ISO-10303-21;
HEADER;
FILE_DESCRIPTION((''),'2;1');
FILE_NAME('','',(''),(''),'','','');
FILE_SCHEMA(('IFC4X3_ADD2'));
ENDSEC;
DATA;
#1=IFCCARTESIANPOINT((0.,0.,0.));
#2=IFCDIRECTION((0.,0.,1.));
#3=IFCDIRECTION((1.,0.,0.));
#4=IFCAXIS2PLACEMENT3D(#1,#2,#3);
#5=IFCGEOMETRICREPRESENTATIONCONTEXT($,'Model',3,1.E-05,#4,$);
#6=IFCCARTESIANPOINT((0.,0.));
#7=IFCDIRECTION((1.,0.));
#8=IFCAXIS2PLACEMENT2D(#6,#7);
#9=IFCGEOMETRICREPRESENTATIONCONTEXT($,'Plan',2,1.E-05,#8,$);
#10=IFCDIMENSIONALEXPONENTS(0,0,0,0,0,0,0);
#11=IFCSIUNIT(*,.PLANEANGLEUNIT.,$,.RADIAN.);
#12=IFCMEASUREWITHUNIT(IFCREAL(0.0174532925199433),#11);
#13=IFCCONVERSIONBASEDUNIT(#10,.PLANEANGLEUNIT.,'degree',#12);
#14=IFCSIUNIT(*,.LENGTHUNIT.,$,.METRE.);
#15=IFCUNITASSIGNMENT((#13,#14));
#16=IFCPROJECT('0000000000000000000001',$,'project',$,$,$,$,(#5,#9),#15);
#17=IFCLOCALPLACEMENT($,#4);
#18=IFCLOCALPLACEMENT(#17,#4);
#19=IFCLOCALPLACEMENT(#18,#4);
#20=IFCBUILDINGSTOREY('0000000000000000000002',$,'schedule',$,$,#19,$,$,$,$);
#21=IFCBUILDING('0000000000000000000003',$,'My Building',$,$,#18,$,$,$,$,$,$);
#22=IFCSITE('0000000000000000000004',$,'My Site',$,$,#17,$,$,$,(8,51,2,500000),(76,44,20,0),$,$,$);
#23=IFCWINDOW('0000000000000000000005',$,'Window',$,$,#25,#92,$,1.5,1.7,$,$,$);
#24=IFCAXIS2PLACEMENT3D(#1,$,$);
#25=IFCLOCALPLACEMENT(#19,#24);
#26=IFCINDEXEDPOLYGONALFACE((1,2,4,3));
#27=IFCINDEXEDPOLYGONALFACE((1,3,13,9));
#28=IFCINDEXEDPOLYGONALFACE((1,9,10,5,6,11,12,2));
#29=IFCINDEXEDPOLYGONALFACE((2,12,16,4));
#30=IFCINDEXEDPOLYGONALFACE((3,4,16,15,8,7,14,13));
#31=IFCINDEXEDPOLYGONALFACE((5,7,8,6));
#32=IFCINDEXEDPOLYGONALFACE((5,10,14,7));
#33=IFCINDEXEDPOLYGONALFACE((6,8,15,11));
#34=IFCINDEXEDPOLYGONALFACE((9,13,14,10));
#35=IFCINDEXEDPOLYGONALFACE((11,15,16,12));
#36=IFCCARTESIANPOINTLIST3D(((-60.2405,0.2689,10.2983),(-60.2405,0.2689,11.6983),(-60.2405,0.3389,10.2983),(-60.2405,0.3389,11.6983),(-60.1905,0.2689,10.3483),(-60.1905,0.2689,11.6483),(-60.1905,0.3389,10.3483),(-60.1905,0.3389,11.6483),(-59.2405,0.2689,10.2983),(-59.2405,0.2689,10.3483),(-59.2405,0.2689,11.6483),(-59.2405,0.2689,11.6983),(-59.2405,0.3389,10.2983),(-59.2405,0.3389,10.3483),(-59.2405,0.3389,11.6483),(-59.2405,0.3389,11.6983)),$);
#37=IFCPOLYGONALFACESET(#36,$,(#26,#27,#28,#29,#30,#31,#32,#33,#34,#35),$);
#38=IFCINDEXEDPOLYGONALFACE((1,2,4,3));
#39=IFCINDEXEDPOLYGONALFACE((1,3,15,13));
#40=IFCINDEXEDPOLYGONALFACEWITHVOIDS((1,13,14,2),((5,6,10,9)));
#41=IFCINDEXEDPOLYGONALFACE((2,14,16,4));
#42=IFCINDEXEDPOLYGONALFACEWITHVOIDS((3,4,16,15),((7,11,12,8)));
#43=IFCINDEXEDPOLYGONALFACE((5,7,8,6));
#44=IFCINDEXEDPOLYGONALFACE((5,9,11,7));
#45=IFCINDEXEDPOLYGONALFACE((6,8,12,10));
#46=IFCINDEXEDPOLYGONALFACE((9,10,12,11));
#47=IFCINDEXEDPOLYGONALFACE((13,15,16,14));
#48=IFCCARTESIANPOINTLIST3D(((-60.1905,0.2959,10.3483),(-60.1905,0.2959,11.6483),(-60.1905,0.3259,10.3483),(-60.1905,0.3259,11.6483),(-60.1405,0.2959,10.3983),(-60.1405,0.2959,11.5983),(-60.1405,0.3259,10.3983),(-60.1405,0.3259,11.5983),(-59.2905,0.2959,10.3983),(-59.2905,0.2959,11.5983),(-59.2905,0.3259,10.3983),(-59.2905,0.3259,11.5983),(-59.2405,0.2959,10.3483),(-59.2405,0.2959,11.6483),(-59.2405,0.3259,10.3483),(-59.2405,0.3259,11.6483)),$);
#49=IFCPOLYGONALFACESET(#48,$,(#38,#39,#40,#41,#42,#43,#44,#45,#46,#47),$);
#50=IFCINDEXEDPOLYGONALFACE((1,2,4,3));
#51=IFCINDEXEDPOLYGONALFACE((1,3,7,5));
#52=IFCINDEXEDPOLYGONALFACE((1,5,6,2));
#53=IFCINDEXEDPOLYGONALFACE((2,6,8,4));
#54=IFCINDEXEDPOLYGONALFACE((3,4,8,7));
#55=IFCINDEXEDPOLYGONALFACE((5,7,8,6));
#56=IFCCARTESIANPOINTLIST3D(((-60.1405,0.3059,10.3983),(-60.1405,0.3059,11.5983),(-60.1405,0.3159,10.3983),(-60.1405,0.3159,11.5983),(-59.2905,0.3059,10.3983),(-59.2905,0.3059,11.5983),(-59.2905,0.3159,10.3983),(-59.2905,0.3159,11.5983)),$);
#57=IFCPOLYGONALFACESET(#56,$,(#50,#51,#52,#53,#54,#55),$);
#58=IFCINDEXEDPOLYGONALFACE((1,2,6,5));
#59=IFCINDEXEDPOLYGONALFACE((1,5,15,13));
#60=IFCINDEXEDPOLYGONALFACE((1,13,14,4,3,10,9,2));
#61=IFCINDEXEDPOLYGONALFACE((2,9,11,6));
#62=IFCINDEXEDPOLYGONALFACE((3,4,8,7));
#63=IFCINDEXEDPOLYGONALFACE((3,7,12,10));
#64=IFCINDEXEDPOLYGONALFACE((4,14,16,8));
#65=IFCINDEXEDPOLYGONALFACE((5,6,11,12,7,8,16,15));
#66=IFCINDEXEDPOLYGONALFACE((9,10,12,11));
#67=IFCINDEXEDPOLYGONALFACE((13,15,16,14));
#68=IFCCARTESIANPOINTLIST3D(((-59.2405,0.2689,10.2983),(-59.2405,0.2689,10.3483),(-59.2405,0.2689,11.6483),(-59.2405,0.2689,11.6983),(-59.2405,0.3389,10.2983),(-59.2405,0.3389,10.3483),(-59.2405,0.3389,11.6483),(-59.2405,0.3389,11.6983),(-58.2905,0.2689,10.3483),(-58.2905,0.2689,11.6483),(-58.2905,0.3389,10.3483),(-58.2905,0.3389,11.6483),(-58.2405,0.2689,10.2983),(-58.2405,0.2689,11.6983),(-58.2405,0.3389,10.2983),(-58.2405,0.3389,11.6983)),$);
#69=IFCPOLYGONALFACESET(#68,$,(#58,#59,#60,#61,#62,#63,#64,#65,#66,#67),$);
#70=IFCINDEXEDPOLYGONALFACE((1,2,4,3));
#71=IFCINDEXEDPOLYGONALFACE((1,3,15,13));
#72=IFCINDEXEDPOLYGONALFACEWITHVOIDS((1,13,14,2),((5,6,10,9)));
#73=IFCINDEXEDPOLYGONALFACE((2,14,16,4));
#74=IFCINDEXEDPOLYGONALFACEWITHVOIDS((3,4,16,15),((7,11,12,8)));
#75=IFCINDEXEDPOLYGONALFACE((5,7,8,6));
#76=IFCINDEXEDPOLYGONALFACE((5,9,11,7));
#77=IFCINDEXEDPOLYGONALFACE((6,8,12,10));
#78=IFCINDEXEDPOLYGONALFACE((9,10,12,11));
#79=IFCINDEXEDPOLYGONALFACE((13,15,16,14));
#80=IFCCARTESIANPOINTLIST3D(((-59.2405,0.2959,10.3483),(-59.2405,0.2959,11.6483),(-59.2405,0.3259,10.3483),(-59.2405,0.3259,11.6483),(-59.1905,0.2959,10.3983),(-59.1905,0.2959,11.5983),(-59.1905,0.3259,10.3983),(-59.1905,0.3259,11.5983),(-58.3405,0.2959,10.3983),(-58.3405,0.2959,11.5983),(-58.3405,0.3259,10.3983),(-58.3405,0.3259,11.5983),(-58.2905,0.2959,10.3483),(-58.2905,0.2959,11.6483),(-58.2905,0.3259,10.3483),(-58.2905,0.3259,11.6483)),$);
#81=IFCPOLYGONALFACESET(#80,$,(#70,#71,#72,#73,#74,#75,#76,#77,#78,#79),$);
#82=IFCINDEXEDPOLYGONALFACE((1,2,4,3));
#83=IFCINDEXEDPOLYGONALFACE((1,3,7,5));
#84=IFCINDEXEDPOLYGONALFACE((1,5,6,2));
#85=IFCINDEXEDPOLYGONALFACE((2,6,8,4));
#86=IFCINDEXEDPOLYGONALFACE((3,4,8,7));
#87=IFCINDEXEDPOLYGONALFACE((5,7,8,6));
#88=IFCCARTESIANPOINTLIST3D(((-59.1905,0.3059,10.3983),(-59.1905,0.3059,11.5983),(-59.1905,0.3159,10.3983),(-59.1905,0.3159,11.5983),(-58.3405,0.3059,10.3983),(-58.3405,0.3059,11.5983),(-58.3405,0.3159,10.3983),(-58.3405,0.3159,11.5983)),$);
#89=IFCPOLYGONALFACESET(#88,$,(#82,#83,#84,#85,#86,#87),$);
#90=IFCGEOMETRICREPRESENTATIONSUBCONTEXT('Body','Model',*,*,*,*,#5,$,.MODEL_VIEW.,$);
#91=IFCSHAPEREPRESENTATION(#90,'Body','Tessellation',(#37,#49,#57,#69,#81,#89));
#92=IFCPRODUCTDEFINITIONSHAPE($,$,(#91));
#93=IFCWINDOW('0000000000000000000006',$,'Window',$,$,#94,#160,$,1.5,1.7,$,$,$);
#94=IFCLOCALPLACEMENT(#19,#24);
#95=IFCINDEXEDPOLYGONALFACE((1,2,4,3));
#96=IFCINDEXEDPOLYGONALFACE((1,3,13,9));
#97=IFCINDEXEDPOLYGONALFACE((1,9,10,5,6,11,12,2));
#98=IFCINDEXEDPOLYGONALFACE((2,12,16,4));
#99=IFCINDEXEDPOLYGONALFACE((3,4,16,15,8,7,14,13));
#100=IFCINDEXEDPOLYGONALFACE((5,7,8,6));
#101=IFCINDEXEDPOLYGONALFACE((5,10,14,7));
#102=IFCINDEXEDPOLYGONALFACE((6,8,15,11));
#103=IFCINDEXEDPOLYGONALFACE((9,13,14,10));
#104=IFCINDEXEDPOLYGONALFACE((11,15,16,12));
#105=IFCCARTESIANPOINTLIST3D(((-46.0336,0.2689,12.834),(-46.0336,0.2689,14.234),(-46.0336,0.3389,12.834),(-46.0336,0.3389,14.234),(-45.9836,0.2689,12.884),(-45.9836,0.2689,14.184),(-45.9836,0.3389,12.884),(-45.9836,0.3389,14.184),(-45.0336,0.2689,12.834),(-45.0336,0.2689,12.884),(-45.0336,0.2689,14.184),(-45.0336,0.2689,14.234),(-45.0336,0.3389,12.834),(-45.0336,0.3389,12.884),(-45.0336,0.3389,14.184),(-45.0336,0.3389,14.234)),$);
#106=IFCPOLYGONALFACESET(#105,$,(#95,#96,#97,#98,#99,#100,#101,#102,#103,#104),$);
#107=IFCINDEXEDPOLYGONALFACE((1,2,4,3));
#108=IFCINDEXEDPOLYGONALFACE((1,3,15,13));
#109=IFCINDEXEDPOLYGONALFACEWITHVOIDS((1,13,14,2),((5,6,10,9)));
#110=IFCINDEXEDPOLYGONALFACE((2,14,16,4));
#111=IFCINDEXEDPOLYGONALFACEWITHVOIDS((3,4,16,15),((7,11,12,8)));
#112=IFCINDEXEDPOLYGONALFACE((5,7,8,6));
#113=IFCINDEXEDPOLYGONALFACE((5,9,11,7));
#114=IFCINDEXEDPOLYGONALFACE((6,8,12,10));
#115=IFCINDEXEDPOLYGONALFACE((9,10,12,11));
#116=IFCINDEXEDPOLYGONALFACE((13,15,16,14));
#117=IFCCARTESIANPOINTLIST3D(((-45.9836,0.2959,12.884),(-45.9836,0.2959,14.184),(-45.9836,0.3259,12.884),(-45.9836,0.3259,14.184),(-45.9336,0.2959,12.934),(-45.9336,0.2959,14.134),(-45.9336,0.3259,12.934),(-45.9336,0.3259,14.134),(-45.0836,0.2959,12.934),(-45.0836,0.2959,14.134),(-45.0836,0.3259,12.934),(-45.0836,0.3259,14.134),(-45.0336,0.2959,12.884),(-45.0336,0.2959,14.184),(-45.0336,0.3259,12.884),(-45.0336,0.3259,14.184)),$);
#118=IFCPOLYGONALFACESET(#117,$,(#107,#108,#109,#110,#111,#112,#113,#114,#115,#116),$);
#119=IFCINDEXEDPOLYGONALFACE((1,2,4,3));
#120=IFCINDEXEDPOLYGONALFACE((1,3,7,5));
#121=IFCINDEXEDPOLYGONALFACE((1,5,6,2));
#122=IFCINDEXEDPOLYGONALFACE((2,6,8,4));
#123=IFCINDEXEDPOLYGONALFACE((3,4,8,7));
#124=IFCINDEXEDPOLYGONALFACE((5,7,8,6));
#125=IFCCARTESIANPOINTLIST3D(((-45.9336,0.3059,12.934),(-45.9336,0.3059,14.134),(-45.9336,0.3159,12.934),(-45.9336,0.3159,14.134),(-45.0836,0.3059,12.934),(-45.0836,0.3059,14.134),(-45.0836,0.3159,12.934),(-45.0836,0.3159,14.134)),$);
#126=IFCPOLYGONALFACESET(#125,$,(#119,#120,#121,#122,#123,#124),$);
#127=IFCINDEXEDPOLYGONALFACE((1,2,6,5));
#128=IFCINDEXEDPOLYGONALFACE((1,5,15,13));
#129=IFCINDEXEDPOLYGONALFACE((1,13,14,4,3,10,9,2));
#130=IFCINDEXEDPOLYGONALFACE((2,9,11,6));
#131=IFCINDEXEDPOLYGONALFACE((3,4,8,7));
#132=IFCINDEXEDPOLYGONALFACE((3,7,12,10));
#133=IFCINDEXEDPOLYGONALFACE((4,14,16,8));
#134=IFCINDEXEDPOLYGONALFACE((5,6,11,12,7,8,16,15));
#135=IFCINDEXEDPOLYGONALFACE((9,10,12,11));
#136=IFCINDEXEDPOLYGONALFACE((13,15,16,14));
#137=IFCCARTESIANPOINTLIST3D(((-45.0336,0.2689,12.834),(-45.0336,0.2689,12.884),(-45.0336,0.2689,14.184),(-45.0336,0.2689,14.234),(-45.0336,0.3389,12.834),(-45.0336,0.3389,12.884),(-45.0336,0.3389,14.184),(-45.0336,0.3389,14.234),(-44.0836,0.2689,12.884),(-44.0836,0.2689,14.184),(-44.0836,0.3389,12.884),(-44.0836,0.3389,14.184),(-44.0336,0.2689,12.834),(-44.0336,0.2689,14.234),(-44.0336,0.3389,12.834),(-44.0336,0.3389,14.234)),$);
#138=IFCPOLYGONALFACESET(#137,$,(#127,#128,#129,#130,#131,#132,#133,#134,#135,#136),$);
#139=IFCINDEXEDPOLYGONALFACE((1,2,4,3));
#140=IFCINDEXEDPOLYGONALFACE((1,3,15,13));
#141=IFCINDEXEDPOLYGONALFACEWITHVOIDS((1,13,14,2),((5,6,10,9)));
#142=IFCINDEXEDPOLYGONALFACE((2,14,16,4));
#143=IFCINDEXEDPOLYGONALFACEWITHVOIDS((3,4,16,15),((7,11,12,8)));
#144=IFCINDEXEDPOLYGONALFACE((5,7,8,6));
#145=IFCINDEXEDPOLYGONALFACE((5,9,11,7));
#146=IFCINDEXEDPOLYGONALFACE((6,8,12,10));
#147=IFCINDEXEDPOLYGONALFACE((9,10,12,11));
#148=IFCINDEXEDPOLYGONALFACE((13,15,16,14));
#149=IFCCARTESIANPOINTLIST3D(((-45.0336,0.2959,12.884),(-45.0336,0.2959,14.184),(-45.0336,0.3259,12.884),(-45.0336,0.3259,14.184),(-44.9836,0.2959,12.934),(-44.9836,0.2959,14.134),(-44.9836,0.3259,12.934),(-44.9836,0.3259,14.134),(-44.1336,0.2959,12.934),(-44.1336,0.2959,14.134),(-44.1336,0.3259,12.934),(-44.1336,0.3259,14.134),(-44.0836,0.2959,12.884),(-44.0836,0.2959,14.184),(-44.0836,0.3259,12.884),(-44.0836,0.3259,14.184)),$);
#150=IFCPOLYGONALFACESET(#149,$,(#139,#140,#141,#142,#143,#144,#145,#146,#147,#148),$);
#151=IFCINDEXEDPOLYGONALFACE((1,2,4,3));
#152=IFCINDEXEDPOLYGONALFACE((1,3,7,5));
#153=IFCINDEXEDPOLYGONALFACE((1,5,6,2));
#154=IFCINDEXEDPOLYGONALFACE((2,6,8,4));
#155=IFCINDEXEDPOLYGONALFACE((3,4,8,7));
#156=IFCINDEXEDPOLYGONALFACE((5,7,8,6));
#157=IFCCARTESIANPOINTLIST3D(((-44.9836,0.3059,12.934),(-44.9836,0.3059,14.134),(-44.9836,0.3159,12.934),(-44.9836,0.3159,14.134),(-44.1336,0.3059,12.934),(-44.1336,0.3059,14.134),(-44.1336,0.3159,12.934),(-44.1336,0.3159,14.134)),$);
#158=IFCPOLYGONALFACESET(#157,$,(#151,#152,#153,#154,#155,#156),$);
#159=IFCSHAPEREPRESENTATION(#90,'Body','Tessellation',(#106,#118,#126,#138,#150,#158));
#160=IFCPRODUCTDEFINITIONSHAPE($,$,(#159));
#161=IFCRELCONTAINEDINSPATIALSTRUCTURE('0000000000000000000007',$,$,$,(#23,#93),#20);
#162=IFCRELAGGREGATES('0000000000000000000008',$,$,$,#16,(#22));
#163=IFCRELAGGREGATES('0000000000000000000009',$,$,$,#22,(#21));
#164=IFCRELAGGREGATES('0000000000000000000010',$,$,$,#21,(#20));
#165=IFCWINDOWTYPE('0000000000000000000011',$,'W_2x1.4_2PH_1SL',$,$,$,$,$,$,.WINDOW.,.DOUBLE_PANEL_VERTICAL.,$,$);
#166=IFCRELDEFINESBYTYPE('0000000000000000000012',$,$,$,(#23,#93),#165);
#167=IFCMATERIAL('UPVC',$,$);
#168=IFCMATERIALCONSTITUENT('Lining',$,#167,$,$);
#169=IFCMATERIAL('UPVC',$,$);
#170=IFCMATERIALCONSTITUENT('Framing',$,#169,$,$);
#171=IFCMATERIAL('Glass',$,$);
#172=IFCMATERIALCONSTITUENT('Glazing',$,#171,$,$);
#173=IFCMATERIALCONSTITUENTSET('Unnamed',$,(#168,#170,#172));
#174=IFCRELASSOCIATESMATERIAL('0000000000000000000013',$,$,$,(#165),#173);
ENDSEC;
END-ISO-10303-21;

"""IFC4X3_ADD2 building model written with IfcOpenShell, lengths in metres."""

from ifc_helpers import new_model, entity, si_unit, converted_unit, frame, origin_with_axes, origin_2d_with_axis, place, context, subcontext, project, spatial, line, indexed_curve, outline, extrude, shape, source, transform, mapped, material, constituent, constituent_set, type_object, type_shapes, element, save


model = new_model("IFC4X3_ADD2")

# Units and contexts
model_context = context("Model", 3, precision=1e-05, world=origin_with_axes())
plan_context = context("Plan", 2, precision=1e-05, world=origin_2d_with_axis())
body_context_1 = subcontext(model_context, "Body", "Model", "MODEL_VIEW")
body_context_2 = subcontext(plan_context, "Body", "Plan", "PLAN_VIEW")
ifc_project = project(units=[converted_unit("PLANEANGLEUNIT", "degree", entity("IfcReal", 0.0174532925199433), si_unit("PLANEANGLEUNIT", "RADIAN"), dimensions=[0, 0, 0, 0, 0, 0, 0]), si_unit("LENGTHUNIT", "METRE")], contexts=[model_context, plan_context])

# Site, building, storey
site_placement = place(None, origin_with_axes())
site = spatial("IfcSite", under=ifc_project, at=site_placement, Name="My Site", RefLatitude=(8, 51, 2, 500000), RefLongitude=(76, 44, 20, 0))
building_placement = place(site_placement, origin_with_axes())
building = spatial("IfcBuilding", under=site, at=building_placement, Name="My Building")
storey_placement = place(building_placement, origin_with_axes())
storey = spatial("IfcBuildingStorey", under=building, at=storey_placement, Name="schedule")

# Windows
ifc_material_1 = material(Name="UPVC")
ifc_constituent_1 = constituent(ifc_material_1, Name="Lining")
ifc_material_2 = material(Name="UPVC")
ifc_constituent_2 = constituent(ifc_material_2, Name="Framing")
ifc_material_3 = material(Name="Glass")
ifc_constituent_3 = constituent(ifc_material_3, Name="Glazing")
ifc_constituent_set_1 = constituent_set(constituents=[ifc_constituent_1, ifc_constituent_2, ifc_constituent_3], Name="Unnamed")
window_type_1 = type_object("IfcWindowType", Name="W_2x1.4_2PH_1SL", PartitioningType="DOUBLE_PANEL_VERTICAL", PredefinedType="WINDOW", material=ifc_constituent_set_1)
shared_shape_1 = source(origin_with_axes(), body_context_1, "Body", "SweptSolid", [
    extrude(outline(indexed_curve([(1.0, 0.0), (0.0, 0.0), (0.0, 1.4), (1.0, 1.4), (1.0, 1.35), (0.05, 1.35), (0.05, 0.05), (1.0, 0.05)], segments=[line(1, 2, 3, 4, 5, 6, 7, 8, 1)])), frame((0.0, 0.0, 0.0), z_axis=(0.0, -1.0, 0.0), x_axis=(1.0, 0.0, 0.0)), (0.0, 0.0, -1.0), 0.07),
    extrude(outline(indexed_curve([(0.0, 0.0), (0.95, 0.0), (0.95, 1.3), (0.0, 1.3)], segments=[line(1, 2, 3, 4, 1)]), holes=[indexed_curve([(0.05, 0.05), (0.9, 0.05), (0.9, 1.25), (0.05, 1.25)], segments=[line(1, 2, 3, 4, 1)])]), frame((0.05, 0.027, 0.05), z_axis=(0.0, -1.0, 0.0), x_axis=(1.0, 0.0, 0.0)), (0.0, 0.0, -1.0), 0.03),
    extrude(outline(indexed_curve([(0.05, 0.05), (0.9, 0.05), (0.9, 1.25), (0.05, 1.25)], segments=[line(1, 2, 3, 4, 1)])), frame((0.05, 0.037, 0.05), z_axis=(0.0, -1.0, 0.0), x_axis=(1.0, 0.0, 0.0)), (0.0, 0.0, -1.0), 0.01),
    extrude(outline(indexed_curve([(0.0, 1.4), (1.0, 1.4), (1.0, 0.0), (0.0, 0.0), (0.0, 0.05), (0.95, 0.05), (0.95, 1.35), (0.0, 1.35)], segments=[line(1, 2, 3, 4, 5, 6, 7, 8, 1)])), frame((1.0, 0.0, 0.0), z_axis=(0.0, -1.0, 0.0), x_axis=(1.0, 0.0, 0.0)), (0.0, 0.0, -1.0), 0.07),
    extrude(outline(indexed_curve([(0.0, 0.0), (0.95, 0.0), (0.95, 1.3), (0.0, 1.3)], segments=[line(1, 2, 3, 4, 1)]), holes=[indexed_curve([(0.05, 0.05), (0.9, 0.05), (0.9, 1.25), (0.05, 1.25)], segments=[line(1, 2, 3, 4, 1)])]), frame((1.0, 0.027, 0.05), z_axis=(0.0, -1.0, 0.0), x_axis=(1.0, 0.0, 0.0)), (0.0, 0.0, -1.0), 0.03),
    extrude(outline(indexed_curve([(0.05, 0.05), (0.9, 0.05), (0.9, 1.25), (0.05, 1.25)], segments=[line(1, 2, 3, 4, 1)])), frame((1.0, 0.037, 0.05), z_axis=(0.0, -1.0, 0.0), x_axis=(1.0, 0.0, 0.0)), (0.0, 0.0, -1.0), 0.01),
])
shared_shape_2 = source(origin_with_axes(), body_context_2, "Body", "Curve2D", [
    entity("IfcIndexedPolyCurve", entity("IfcCartesianPointList2D", [[0.05, 0.0], [1.0, 0.0]])),
    entity("IfcIndexedPolyCurve", entity("IfcCartesianPointList2D", [[0.0, 0.07], [0.05, 0.07], [0.05, 0.0], [0.0, 0.0]]), [entity("IfcLineIndex", [1, 2, 3, 4, 1])]),
    entity("IfcIndexedPolyCurve", entity("IfcCartesianPointList2D", [[1.0, 0.07], [1.0, 0.07], [1.0, 0.0], [1.0, 0.0]])),
    entity("IfcIndexedPolyCurve", entity("IfcCartesianPointList2D", [[0.05, 0.027], [0.1, 0.027], [0.1, 0.057], [0.05, 0.057]]), [entity("IfcLineIndex", [1, 2, 3, 4, 1])]),
    entity("IfcIndexedPolyCurve", entity("IfcCartesianPointList2D", [[1.0, 0.027], [0.95, 0.027], [0.95, 0.057], [1.0, 0.057]]), [entity("IfcLineIndex", [1, 2, 3, 4, 1])]),
    entity("IfcIndexedPolyCurve", entity("IfcCartesianPointList2D", [[0.1, 0.027], [0.95, 0.027]])),
    entity("IfcIndexedPolyCurve", entity("IfcCartesianPointList2D", [[0.1, 0.057], [0.95, 0.057]])),
    entity("IfcIndexedPolyCurve", entity("IfcCartesianPointList2D", [[0.1, 0.042], [0.95, 0.042]])),
    entity("IfcIndexedPolyCurve", entity("IfcCartesianPointList2D", [[1.0, 0.0], [1.95, 0.0]])),
    entity("IfcIndexedPolyCurve", entity("IfcCartesianPointList2D", [[1.0, 0.07], [1.0, 0.07], [1.0, 0.0], [1.0, 0.0]])),
    entity("IfcIndexedPolyCurve", entity("IfcCartesianPointList2D", [[2.0, 0.07], [1.95, 0.07], [1.95, 0.0], [2.0, 0.0]]), [entity("IfcLineIndex", [1, 2, 3, 4, 1])]),
    entity("IfcIndexedPolyCurve", entity("IfcCartesianPointList2D", [[1.0, 0.027], [1.05, 0.027], [1.05, 0.057], [1.0, 0.057]]), [entity("IfcLineIndex", [1, 2, 3, 4, 1])]),
    entity("IfcIndexedPolyCurve", entity("IfcCartesianPointList2D", [[1.95, 0.027], [1.9, 0.027], [1.9, 0.057], [1.95, 0.057]]), [entity("IfcLineIndex", [1, 2, 3, 4, 1])]),
    entity("IfcIndexedPolyCurve", entity("IfcCartesianPointList2D", [[1.05, 0.027], [1.9, 0.027]])),
    entity("IfcIndexedPolyCurve", entity("IfcCartesianPointList2D", [[1.05, 0.057], [1.9, 0.057]])),
    entity("IfcIndexedPolyCurve", entity("IfcCartesianPointList2D", [[1.05, 0.042], [1.9, 0.042]])),
])
type_shapes(window_type_1, [shared_shape_1, shared_shape_2])
placement_1 = place(storey_placement, frame((-67.8485, 0.2689, 3.1152), z_axis=(0.0, 0.0, 1.0), x_axis=(1.0, 0.0, 0.0)))
placement_2 = place(placement_1, frame((7.608, 0.0, 7.1831), z_axis=(0.0, 0.0, 1.0), x_axis=(1.0, 0.0, 0.0)))
window_1_placement = place(placement_2, origin_with_axes())
element("IfcWindow", 1, at=window_1_placement, inside=storey, type_object=window_type_1, Name="Window", OverallHeight=1.5, OverallWidth=1.7, shapes=[
    shape(body_context_1, "Body", "MappedRepresentation", [mapped(shared_shape_1, transform((0.0, 0.0, 0.0), x_axis=(1.0, 0.0, 0.0), y_axis=(0.0, 1.0, 0.0), z_axis=(0.0, 0.0, 1.0), scale=1.0))]),
    shape(body_context_2, "Body", "MappedRepresentation", [mapped(shared_shape_2, transform((0.0, 0.0, 0.0), x_axis=(1.0, 0.0, 0.0), y_axis=(0.0, 1.0, 0.0), z_axis=(0.0, 0.0, 1.0), scale=1.0))]),
])
placement_3 = place(placement_1, frame((21.8149, 0.0, 9.7188), z_axis=(0.0, 0.0, 1.0), x_axis=(1.0, 0.0, 0.0)))
window_2_placement = place(placement_3, origin_with_axes())
element("IfcWindow", 2, at=window_2_placement, inside=storey, type_object=window_type_1, Name="Window", OverallHeight=1.5, OverallWidth=1.7, shapes=[
    shape(body_context_1, "Body", "MappedRepresentation", [mapped(shared_shape_1, transform((0.0, 0.0, 0.0), x_axis=(1.0, 0.0, 0.0), y_axis=(0.0, 1.0, 0.0), z_axis=(0.0, 0.0, 1.0), scale=1.0))]),
    shape(body_context_2, "Body", "MappedRepresentation", [mapped(shared_shape_2, transform((0.0, 0.0, 0.0), x_axis=(1.0, 0.0, 0.0), y_axis=(0.0, 1.0, 0.0), z_axis=(0.0, 0.0, 1.0), scale=1.0))]),
])

save(model, "model.ifc")
